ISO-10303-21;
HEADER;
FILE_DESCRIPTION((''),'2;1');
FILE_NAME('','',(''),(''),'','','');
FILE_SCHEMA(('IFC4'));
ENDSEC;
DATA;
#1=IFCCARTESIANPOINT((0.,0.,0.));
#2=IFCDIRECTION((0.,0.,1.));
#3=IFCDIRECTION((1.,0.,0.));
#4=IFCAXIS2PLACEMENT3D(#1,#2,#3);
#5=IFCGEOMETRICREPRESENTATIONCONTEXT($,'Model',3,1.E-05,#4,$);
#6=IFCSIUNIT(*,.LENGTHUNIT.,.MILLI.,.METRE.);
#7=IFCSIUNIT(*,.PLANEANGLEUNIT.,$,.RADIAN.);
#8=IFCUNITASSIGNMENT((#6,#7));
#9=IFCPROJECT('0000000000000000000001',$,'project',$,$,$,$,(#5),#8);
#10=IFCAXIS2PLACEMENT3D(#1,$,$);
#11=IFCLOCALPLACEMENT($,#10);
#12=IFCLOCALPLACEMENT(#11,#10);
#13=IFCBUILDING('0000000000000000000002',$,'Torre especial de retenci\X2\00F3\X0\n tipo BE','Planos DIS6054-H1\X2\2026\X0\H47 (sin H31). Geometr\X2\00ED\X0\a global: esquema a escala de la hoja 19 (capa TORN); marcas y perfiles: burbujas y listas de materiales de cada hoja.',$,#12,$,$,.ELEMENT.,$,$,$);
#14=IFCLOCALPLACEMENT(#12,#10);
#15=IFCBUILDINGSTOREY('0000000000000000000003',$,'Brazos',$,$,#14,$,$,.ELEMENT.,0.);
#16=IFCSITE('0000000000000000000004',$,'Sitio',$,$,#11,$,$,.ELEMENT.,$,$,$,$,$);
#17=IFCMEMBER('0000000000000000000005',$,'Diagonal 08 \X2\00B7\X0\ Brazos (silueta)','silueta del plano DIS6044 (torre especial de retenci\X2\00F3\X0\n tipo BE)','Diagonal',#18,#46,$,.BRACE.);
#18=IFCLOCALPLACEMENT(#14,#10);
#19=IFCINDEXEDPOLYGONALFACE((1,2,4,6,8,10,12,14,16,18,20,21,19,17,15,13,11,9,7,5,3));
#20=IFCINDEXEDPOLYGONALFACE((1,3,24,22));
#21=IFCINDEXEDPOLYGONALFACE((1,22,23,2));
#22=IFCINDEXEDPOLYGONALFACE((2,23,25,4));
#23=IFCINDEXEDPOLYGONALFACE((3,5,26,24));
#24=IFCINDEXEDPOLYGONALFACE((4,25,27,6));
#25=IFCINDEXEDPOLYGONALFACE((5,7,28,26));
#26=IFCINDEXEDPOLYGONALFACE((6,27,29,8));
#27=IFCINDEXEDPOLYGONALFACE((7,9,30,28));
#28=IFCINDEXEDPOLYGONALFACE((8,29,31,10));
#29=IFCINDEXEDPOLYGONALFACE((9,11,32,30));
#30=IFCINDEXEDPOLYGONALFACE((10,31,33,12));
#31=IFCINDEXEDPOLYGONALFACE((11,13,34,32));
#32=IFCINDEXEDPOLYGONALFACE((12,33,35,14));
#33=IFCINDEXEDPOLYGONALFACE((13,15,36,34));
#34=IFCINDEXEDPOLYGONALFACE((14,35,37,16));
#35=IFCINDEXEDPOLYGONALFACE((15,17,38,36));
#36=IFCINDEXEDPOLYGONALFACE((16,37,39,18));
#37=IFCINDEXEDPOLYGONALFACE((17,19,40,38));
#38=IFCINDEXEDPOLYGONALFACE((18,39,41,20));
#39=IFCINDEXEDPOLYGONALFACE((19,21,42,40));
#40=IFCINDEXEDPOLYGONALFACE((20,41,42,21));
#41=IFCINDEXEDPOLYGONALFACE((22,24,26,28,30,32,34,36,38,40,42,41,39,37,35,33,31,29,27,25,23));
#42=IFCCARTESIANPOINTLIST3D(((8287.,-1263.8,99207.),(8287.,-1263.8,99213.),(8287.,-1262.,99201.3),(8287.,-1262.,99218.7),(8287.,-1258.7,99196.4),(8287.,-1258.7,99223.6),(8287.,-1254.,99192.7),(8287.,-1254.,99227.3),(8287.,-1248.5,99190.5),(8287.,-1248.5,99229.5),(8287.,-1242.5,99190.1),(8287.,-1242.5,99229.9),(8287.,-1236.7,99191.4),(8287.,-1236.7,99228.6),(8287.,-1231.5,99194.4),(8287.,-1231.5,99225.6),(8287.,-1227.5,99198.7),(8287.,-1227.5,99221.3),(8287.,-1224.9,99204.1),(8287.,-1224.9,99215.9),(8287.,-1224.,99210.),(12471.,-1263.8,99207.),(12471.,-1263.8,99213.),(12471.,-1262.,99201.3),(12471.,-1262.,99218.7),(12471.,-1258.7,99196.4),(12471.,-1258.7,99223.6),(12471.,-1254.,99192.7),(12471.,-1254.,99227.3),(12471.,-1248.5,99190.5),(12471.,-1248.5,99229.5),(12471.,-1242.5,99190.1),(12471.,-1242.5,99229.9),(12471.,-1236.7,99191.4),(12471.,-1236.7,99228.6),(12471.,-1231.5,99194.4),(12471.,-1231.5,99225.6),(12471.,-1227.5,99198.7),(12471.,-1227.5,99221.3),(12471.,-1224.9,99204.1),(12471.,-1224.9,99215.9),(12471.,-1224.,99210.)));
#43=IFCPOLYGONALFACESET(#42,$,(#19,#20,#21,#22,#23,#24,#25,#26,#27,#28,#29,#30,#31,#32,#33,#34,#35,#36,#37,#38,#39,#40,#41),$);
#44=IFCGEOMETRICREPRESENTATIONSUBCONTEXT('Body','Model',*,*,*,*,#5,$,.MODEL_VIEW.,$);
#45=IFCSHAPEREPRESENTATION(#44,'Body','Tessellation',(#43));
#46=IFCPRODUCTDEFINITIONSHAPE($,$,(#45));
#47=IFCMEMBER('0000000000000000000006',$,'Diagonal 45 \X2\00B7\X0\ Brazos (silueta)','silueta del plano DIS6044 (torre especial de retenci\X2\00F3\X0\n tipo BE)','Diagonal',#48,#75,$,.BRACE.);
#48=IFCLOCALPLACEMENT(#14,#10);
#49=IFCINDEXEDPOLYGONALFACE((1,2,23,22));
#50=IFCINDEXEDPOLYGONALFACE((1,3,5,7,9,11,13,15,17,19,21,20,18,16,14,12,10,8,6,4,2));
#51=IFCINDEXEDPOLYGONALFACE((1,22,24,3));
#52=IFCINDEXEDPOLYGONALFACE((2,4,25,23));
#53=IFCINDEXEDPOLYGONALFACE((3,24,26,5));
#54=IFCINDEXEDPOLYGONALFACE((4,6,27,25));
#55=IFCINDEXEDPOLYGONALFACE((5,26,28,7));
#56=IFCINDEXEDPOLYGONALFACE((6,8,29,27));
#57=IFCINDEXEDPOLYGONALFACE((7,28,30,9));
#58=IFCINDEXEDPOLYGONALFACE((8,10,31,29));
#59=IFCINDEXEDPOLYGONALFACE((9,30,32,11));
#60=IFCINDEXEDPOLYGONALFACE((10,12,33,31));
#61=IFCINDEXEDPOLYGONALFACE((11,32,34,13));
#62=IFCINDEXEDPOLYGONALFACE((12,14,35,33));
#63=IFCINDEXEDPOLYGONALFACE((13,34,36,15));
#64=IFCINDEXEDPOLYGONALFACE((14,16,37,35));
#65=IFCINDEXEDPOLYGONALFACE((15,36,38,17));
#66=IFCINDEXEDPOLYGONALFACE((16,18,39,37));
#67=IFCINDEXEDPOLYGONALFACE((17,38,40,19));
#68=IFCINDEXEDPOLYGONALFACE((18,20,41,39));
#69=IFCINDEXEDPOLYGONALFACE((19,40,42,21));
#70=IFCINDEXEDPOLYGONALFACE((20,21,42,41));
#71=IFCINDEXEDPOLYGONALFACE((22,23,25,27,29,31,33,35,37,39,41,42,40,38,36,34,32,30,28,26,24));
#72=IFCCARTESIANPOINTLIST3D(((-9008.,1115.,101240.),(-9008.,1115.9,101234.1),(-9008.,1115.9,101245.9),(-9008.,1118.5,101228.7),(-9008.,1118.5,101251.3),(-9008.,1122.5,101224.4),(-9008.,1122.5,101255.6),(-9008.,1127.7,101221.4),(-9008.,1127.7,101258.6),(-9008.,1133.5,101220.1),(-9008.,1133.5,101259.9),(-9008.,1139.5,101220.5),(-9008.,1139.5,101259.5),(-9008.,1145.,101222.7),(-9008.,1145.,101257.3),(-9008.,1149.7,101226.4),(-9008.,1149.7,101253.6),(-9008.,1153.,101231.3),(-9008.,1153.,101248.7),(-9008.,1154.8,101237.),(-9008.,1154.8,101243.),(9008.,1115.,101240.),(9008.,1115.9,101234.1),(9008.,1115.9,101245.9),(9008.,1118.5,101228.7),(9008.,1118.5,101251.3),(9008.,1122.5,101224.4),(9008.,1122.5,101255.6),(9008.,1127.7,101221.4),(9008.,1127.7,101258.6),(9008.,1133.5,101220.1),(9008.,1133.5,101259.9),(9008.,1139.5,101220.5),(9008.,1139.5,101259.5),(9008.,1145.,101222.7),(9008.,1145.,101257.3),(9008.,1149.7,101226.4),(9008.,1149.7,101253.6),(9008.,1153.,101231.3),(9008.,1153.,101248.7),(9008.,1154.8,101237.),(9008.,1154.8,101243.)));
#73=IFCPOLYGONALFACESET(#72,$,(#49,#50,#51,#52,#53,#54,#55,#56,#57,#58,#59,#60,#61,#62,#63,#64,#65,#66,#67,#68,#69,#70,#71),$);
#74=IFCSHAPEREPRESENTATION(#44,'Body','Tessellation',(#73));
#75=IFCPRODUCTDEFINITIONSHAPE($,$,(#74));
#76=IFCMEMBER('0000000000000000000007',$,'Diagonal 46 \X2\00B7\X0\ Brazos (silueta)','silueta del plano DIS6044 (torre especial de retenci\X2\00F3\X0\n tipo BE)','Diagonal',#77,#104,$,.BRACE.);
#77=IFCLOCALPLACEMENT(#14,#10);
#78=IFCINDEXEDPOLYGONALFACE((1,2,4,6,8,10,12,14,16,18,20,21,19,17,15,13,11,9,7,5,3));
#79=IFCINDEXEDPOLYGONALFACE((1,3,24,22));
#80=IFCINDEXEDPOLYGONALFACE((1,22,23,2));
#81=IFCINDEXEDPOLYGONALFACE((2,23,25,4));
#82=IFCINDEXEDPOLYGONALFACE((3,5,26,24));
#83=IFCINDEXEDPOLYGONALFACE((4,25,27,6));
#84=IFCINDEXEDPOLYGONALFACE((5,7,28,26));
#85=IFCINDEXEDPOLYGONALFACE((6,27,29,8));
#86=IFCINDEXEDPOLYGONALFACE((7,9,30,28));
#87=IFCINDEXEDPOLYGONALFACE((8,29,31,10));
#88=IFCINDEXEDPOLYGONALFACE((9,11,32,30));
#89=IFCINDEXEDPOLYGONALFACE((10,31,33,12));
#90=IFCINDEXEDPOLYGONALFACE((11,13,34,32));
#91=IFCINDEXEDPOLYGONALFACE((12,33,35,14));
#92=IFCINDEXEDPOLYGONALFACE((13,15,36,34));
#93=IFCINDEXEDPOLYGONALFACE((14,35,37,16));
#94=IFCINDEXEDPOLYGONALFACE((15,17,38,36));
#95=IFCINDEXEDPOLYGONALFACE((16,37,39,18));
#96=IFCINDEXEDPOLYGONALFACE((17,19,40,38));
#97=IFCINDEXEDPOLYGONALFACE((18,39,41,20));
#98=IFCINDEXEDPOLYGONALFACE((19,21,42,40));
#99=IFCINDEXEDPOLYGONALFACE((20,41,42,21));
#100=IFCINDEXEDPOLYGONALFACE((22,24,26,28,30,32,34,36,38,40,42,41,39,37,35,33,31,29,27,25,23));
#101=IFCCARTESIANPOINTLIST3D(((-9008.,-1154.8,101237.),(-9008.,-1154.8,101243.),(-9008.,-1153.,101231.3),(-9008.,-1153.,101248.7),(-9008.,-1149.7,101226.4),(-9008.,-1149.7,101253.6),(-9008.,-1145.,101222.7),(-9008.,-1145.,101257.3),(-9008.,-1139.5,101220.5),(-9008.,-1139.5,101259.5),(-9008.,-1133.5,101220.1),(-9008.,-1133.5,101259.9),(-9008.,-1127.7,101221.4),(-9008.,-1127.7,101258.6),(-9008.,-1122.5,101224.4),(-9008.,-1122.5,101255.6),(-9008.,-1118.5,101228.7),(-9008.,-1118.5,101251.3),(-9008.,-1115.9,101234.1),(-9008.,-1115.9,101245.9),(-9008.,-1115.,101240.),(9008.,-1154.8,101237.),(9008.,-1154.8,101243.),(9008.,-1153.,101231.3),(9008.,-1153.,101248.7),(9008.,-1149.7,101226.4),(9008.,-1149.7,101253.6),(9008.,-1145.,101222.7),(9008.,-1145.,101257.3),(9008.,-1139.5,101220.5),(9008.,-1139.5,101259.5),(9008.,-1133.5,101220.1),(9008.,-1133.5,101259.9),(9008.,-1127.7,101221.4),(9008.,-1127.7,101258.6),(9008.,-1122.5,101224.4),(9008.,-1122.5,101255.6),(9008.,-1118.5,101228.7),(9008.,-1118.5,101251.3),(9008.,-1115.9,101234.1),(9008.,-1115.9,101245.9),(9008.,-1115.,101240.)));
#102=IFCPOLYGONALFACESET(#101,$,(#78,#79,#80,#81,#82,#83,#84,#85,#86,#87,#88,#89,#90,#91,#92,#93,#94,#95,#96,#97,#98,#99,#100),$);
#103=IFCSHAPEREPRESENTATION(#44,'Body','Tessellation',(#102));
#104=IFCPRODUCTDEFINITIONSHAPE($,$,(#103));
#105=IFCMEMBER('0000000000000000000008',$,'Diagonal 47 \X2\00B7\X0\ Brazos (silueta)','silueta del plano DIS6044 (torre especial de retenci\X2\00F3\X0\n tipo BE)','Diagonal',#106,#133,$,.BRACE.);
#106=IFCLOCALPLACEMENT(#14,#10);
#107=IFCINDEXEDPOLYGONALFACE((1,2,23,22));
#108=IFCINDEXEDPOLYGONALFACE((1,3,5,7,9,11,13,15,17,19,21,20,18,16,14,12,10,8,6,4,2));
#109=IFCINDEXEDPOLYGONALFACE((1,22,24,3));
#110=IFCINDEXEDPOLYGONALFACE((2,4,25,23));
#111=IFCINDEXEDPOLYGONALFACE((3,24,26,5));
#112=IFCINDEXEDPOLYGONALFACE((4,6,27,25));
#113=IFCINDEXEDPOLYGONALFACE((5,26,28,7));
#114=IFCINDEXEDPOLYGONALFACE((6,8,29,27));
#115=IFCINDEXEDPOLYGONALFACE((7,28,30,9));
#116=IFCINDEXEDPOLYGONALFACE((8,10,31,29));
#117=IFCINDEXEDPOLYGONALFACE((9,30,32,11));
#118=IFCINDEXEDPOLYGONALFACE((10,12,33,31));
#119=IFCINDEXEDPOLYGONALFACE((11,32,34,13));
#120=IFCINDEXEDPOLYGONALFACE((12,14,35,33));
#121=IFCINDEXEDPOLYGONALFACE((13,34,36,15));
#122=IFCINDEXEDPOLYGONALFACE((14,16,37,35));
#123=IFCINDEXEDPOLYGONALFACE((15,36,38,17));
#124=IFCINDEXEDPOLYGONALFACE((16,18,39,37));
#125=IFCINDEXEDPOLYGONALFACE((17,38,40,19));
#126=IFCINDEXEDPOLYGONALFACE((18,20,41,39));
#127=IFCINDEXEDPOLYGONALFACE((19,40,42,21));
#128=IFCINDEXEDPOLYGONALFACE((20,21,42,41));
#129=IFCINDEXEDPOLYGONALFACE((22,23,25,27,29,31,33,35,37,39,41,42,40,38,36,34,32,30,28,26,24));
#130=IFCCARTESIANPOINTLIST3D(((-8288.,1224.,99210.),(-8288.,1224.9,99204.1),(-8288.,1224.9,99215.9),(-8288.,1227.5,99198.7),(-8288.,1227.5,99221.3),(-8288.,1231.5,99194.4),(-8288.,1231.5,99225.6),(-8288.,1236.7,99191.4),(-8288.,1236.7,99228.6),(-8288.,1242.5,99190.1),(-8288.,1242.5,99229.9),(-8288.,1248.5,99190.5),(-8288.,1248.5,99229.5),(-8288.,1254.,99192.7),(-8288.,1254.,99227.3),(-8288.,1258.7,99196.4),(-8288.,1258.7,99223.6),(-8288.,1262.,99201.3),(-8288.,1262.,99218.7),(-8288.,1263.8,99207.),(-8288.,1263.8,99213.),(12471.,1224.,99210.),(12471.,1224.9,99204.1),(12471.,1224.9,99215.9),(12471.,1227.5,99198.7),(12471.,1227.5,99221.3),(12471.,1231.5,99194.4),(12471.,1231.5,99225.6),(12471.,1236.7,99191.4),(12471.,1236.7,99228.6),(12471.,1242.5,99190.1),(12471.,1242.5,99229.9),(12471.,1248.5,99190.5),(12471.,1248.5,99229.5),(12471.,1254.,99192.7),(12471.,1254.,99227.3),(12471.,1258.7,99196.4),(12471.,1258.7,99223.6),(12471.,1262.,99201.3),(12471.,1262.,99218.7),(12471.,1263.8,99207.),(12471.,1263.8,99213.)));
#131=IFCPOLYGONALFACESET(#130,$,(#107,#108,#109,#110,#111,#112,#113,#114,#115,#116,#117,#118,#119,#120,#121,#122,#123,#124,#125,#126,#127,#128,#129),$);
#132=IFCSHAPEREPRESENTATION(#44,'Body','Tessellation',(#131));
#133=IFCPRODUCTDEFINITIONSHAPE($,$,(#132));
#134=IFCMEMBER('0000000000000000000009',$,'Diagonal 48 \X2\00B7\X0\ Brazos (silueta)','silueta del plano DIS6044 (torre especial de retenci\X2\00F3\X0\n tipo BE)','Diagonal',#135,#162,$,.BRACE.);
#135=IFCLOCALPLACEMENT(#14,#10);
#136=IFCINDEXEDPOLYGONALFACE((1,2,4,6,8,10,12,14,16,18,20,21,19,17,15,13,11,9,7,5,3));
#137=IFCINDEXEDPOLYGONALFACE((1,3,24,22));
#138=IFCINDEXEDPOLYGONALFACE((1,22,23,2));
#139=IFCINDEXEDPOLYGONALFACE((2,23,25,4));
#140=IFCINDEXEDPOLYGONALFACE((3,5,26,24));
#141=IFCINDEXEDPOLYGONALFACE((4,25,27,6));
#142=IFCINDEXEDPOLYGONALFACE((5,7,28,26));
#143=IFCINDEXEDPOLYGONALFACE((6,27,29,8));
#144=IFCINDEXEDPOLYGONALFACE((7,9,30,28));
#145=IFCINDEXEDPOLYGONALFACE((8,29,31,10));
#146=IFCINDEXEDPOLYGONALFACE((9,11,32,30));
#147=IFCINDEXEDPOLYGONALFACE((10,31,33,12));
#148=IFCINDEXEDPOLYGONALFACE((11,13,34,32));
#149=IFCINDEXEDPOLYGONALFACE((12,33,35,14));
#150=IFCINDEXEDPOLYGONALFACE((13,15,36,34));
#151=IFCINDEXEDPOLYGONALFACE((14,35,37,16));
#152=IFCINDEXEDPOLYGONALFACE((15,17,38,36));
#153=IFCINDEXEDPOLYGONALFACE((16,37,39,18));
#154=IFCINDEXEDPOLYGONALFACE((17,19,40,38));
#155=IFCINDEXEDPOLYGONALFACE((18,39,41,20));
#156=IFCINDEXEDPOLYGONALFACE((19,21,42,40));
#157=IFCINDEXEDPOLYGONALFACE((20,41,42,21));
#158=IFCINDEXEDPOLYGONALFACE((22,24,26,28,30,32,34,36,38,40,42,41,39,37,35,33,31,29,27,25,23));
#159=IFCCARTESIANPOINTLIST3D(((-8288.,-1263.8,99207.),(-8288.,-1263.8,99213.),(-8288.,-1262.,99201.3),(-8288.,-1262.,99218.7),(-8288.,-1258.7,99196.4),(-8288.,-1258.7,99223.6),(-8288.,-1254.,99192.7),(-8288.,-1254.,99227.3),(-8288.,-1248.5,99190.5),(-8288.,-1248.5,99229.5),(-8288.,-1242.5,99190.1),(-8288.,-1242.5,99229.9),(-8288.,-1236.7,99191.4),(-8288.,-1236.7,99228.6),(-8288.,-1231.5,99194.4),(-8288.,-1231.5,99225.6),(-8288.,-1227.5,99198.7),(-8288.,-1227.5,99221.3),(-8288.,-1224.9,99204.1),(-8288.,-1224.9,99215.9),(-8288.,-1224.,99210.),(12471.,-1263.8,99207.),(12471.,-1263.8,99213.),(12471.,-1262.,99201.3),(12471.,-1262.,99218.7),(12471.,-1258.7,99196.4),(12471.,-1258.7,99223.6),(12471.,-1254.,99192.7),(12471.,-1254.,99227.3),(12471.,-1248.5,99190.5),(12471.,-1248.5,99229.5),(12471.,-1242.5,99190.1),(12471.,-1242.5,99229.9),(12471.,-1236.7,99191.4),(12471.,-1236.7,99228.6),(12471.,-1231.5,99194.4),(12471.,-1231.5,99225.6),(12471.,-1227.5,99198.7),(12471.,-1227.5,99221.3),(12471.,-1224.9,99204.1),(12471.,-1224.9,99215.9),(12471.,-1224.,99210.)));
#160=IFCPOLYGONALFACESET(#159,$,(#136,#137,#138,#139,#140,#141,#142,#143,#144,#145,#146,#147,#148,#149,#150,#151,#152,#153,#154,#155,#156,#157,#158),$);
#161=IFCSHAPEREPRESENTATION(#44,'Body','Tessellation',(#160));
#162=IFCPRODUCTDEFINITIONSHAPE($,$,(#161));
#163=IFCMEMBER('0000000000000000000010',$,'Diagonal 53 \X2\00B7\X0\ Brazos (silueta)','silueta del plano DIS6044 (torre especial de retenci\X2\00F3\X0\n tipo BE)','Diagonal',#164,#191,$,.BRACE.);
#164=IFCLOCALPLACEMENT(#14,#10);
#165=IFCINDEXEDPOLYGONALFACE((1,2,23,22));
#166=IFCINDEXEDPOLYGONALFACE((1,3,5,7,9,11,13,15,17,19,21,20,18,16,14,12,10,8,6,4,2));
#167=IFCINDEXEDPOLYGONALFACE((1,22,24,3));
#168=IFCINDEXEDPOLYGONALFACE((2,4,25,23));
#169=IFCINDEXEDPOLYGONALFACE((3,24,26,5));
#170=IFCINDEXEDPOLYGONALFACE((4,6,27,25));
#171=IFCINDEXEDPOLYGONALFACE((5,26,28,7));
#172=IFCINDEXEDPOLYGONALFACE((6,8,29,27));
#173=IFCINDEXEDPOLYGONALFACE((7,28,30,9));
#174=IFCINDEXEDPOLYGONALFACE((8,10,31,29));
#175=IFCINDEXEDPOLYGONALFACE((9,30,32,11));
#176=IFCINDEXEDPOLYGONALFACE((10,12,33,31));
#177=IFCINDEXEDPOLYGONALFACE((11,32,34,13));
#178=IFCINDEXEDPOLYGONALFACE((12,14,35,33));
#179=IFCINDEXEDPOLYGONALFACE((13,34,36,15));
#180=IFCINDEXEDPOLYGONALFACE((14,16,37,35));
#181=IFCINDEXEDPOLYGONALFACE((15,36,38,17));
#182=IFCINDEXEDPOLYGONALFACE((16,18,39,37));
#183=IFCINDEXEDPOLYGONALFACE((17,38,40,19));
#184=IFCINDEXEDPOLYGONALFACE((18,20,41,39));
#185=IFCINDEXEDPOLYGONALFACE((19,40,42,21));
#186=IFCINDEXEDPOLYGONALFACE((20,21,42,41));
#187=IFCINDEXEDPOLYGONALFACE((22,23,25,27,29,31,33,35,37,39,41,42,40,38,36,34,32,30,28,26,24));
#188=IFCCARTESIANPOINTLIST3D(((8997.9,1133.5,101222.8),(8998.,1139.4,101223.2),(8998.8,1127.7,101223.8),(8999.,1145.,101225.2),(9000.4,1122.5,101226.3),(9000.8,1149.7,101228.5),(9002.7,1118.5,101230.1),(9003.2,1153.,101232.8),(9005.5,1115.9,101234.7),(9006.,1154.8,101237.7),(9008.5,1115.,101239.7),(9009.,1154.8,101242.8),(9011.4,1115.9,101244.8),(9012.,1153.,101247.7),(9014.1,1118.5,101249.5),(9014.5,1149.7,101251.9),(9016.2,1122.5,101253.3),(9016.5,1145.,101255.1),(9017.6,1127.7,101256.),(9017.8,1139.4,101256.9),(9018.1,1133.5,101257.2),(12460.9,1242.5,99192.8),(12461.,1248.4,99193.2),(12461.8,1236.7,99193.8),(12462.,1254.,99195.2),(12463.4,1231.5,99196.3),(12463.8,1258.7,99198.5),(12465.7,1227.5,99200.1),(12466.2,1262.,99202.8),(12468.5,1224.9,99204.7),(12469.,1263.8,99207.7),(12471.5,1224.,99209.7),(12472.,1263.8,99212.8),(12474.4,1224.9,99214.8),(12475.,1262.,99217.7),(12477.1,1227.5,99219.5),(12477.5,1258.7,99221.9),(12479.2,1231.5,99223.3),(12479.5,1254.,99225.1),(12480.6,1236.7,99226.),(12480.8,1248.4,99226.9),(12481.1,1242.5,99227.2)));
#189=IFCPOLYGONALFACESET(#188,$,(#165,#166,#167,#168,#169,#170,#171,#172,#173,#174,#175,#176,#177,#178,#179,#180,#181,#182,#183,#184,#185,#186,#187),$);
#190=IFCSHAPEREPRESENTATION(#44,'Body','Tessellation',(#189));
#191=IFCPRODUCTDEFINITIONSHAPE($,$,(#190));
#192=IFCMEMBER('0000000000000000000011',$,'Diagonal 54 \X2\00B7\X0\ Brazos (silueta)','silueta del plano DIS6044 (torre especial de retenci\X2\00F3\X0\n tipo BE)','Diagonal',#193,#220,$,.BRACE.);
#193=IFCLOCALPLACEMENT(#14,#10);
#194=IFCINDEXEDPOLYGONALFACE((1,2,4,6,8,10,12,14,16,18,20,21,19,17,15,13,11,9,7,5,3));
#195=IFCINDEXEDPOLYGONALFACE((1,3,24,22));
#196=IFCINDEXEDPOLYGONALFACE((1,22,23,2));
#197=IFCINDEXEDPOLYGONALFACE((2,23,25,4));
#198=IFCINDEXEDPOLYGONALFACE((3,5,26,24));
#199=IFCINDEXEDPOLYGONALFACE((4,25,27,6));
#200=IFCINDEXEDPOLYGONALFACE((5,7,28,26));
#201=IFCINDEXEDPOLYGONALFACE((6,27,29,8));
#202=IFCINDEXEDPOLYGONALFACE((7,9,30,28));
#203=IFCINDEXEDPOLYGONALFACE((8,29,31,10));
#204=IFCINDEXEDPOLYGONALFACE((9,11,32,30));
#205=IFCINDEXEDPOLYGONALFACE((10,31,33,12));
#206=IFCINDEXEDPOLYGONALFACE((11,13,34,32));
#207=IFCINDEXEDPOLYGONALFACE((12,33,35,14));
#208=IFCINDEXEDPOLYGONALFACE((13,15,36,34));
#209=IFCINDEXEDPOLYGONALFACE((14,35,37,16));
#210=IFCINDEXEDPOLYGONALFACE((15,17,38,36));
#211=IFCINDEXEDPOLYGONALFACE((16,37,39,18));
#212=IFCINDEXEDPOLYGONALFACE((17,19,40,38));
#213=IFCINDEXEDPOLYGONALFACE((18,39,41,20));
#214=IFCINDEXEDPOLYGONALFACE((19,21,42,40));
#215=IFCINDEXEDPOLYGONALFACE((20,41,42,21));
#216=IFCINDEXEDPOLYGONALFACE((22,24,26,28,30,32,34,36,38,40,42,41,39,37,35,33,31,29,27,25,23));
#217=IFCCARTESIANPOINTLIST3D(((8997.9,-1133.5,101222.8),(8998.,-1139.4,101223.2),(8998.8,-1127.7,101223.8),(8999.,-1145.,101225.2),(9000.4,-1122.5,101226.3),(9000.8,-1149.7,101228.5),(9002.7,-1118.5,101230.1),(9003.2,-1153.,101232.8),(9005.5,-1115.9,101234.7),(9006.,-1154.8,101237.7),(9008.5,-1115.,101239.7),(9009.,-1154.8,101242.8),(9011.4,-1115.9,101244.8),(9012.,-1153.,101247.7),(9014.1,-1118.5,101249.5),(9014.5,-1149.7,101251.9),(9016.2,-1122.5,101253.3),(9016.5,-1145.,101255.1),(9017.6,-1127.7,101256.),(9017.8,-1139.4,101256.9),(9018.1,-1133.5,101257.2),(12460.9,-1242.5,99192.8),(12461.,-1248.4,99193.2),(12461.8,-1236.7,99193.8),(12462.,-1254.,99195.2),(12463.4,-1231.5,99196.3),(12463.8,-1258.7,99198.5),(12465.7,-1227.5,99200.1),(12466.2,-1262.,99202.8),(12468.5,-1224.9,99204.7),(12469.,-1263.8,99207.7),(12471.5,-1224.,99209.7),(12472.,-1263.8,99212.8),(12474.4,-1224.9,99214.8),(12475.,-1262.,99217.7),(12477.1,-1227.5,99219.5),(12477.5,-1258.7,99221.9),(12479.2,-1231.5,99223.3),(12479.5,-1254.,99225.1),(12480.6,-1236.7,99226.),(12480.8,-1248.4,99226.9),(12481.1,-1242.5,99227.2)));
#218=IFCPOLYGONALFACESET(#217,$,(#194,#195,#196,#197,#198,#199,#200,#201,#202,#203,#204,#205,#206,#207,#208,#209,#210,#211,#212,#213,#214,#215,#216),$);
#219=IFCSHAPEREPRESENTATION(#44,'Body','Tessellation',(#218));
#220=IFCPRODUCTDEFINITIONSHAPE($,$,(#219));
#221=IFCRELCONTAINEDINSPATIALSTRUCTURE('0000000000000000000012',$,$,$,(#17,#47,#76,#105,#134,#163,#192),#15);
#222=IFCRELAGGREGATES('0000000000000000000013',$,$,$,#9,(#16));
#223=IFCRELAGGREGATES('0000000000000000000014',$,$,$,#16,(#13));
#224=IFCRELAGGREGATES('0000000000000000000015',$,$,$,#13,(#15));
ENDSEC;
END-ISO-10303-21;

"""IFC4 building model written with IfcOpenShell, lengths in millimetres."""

from ifc_helpers import new_model, si_unit, frame, origin, origin_with_axes, place, context, subcontext, project, spatial, circle, extrude, element, save


model = new_model("IFC4")

# Units and contexts
model_context = context("Model", 3, precision=1e-05, world=origin_with_axes())
body_context = subcontext(model_context, "Body", "Model", "MODEL_VIEW")
ifc_project = project(units=[si_unit("LENGTHUNIT", "METRE", prefix="MILLI"), si_unit("PLANEANGLEUNIT", "RADIAN")], contexts=[model_context])

# Site, building, storey
site_placement = place(None, origin())
site = spatial("IfcSite", under=ifc_project, at=site_placement, Name="Sitio", CompositionType="ELEMENT")
building_placement = place(site_placement, origin())
building = spatial("IfcBuilding", under=site, at=building_placement, Name="Torre especial de retención tipo BE", Description="Planos DIS6054-H1…H47 (sin H31). Geometría global: esquema a escala de la hoja 19 (capa TORN); marcas y perfiles: burbujas y listas de materiales de cada hoja.", CompositionType="ELEMENT")
storey_placement = place(building_placement, origin())
storey = spatial("IfcBuildingStorey", under=building, at=storey_placement, Name="Brazos", CompositionType="ELEMENT", Elevation=0.0)

# Members
member_1_placement = place(storey_placement, frame((8287.0, -1244.0, 99210.0), z_axis=(1.0, 0.0, 0.0), x_axis=(0.0, 1.0, 0.0)))
element("IfcMember", 1, at=member_1_placement, inside=storey, Name="Diagonal 08 · Brazos (silueta)", Description="silueta del plano DIS6044 (torre especial de retención tipo BE)", ObjectType="Diagonal", PredefinedType="BRACE", context=body_context, shape_type="SweptSolid", body=[
    extrude(circle(Radius=20.0), None, (0.0, 0.0, 1.0), 4184.0),
])
for number, where, z_axis, x_axis, name in (
    (2, (9008.0, 1135.0, 101240.0), (-1.0, 0.0, 0.0), (0.0, -1.0, 0.0), "Diagonal 45 · Brazos (silueta)"),
    (3, (9008.0, -1135.0, 101240.0), (-1.0, 0.0, 0.0), (0.0, 1.0, 0.0), "Diagonal 46 · Brazos (silueta)"),
):
    element("IfcMember", number, at=place(storey_placement, frame(where, z_axis=z_axis, x_axis=x_axis)), inside=storey, Name=name, Description="silueta del plano DIS6044 (torre especial de retención tipo BE)", ObjectType="Diagonal", PredefinedType="BRACE", context=body_context, shape_type="SweptSolid", body=[
        extrude(circle(Radius=20.0), None, (0.0, 0.0, 1.0), 18016.0),
    ])
for number, where, z_axis, x_axis, name in (
    (4, (12471.0, 1244.0, 99210.0), (-1.0, 0.0, 0.0), (0.0, -1.0, 0.0), "Diagonal 47 · Brazos (silueta)"),
    (5, (12471.0, -1244.0, 99210.0), (-1.0, 0.0, 0.0), (0.0, 1.0, 0.0), "Diagonal 48 · Brazos (silueta)"),
):
    element("IfcMember", number, at=place(storey_placement, frame(where, z_axis=z_axis, x_axis=x_axis)), inside=storey, Name=name, Description="silueta del plano DIS6044 (torre especial de retención tipo BE)", ObjectType="Diagonal", PredefinedType="BRACE", context=body_context, shape_type="SweptSolid", body=[
        extrude(circle(Radius=20.0), None, (0.0, 0.0, 1.0), 20759.0),
    ])
for number, where, z_axis, x_axis, name in (
    (6, (12471.0, 1244.0, 99210.0), (-0.862384, -0.027144, 0.505527), (0.023417, -0.999632, -0.013727), "Diagonal 53 · Brazos (silueta)"),
    (7, (12471.0, -1244.0, 99210.0), (-0.862384, 0.027144, 0.505527), (0.023417, 0.999632, -0.013727), "Diagonal 54 · Brazos (silueta)"),
):
    element("IfcMember", number, at=place(storey_placement, frame(where, z_axis=z_axis, x_axis=x_axis)), inside=storey, Name=name, Description="silueta del plano DIS6044 (torre especial de retención tipo BE)", ObjectType="Diagonal", PredefinedType="BRACE", context=body_context, shape_type="SweptSolid", body=[
        extrude(circle(Radius=20.0), None, (0.0, 0.0, 1.0), 4015.6),
    ])

save(model, "model.ifc")
